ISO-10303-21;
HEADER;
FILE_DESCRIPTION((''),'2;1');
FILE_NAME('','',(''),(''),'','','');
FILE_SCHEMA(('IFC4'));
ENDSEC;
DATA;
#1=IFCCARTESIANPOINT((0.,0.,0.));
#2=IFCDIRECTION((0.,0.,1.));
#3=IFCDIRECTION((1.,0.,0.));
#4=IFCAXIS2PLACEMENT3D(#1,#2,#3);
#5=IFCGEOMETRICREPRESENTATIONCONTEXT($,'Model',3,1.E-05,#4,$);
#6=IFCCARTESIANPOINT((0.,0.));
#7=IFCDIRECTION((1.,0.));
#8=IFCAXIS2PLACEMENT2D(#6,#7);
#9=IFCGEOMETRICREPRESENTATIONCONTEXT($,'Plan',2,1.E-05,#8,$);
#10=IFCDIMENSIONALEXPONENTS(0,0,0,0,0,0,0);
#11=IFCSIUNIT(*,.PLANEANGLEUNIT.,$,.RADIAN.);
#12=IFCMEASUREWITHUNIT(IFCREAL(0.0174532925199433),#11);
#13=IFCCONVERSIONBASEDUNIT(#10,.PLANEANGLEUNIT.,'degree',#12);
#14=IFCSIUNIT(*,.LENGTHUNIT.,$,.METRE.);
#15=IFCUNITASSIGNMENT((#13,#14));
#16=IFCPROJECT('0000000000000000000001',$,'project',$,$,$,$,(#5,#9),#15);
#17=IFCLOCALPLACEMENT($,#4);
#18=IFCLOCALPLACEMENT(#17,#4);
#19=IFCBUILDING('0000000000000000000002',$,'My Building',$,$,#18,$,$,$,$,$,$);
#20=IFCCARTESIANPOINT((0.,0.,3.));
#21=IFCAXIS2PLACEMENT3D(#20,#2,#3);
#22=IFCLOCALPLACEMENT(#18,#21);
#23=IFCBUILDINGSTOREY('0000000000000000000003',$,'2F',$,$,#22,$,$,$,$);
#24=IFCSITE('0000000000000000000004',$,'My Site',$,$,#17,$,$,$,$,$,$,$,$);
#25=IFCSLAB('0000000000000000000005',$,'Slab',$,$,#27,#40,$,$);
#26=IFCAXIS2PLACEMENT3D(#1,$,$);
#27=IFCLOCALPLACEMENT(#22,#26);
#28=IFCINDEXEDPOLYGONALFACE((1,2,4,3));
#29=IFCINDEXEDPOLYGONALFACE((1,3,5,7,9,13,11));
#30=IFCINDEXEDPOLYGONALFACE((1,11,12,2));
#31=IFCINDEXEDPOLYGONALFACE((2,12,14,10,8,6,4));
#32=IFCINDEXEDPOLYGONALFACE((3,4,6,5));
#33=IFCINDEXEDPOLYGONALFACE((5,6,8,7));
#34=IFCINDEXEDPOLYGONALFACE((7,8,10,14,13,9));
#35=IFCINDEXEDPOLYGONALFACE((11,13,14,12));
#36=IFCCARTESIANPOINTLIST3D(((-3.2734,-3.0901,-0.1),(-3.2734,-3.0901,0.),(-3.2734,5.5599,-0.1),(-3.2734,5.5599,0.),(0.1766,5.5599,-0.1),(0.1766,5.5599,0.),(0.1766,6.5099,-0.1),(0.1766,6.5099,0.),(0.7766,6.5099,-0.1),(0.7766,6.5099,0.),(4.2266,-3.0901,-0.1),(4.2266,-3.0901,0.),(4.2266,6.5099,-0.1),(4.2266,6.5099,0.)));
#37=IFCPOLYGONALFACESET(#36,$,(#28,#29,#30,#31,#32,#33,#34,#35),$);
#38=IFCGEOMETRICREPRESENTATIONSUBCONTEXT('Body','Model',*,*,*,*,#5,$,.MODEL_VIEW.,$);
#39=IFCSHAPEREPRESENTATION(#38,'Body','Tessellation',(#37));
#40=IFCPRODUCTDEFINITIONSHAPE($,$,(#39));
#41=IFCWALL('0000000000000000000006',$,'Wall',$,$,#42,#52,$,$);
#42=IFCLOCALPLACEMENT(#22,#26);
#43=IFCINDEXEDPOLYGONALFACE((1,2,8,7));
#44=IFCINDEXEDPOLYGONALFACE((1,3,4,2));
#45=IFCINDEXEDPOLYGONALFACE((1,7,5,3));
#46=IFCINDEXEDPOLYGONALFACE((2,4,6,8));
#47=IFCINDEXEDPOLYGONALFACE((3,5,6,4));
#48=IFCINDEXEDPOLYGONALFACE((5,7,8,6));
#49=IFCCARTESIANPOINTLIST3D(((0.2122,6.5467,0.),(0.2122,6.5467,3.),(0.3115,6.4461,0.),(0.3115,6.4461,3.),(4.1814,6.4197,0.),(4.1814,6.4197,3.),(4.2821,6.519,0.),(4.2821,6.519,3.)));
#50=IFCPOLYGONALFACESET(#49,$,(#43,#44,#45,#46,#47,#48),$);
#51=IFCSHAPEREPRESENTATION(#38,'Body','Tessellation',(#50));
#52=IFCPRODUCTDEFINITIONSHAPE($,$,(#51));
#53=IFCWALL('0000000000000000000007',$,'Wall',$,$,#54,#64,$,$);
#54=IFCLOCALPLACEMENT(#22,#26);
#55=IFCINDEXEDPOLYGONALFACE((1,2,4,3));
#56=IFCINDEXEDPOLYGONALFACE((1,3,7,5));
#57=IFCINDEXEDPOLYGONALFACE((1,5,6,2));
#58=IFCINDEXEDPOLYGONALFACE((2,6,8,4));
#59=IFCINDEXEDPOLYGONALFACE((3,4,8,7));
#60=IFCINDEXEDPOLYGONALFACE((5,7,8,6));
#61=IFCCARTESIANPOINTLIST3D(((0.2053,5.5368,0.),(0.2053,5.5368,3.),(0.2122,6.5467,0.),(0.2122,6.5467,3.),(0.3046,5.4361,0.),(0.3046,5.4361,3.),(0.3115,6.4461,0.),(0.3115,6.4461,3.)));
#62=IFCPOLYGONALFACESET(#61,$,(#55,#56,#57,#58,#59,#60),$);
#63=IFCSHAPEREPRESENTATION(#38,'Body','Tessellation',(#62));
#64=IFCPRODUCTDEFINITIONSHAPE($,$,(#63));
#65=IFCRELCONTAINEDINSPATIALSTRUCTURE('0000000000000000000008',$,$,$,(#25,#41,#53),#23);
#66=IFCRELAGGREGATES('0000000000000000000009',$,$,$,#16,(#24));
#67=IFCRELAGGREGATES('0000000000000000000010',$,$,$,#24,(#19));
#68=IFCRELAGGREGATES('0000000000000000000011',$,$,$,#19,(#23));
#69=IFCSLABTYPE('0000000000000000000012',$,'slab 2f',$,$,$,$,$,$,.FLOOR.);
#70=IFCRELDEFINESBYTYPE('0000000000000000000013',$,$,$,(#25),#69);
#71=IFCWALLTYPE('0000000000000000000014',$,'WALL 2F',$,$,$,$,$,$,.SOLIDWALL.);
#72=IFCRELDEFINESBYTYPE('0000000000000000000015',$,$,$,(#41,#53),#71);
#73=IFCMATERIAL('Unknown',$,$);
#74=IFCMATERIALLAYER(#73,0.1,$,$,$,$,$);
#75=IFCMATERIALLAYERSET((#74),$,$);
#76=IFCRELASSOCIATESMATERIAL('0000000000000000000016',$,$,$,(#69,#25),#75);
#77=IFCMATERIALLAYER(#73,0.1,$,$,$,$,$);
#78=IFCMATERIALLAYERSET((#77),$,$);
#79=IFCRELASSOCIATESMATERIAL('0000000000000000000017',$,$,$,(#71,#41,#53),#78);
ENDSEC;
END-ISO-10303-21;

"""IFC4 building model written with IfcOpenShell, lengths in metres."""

from ifc_helpers import new_model, entity, si_unit, converted_unit, frame, origin_with_axes, origin_2d_with_axis, place, context, subcontext, project, spatial, line, indexed_curve, outline, extrude, material, layer, layer_set, layer_usage, type_object, element, save


model = new_model("IFC4")

# Units and contexts
model_context = context("Model", 3, precision=1e-05, world=origin_with_axes())
plan_context = context("Plan", 2, precision=1e-05, world=origin_2d_with_axis())
body_context_1 = subcontext(model_context, "Body", "Model", "MODEL_VIEW")
ifc_project = project(units=[converted_unit("PLANEANGLEUNIT", "degree", entity("IfcReal", 0.0174532925199433), si_unit("PLANEANGLEUNIT", "RADIAN"), dimensions=[0, 0, 0, 0, 0, 0, 0]), si_unit("LENGTHUNIT", "METRE")], contexts=[model_context, plan_context])

# Site, building, storey
site_placement = place(None, origin_with_axes())
site = spatial("IfcSite", under=ifc_project, at=site_placement, Name="My Site")
building_placement = place(site_placement, origin_with_axes())
building = spatial("IfcBuilding", under=site, at=building_placement, Name="My Building")
storey_placement = place(building_placement, frame((0.0, 0.0, 3.0), z_axis=(0.0, 0.0, 1.0), x_axis=(1.0, 0.0, 0.0)))
storey = spatial("IfcBuildingStorey", under=building, at=storey_placement, Name="2F")

# Slab
ifc_material = material(Name="Unknown")
ifc_layer_1 = layer(ifc_material, 0.1)
ifc_layer_set_1 = layer_set([ifc_layer_1])
ifc_layer_usage_1 = layer_usage(ifc_layer_set_1, "AXIS3", "POSITIVE", -0.1)
slab_type = type_object("IfcSlabType", Name="slab 2f", PredefinedType="FLOOR", material=ifc_layer_set_1)
slab_placement = place(storey_placement, frame((0.7766, 6.5099, 0.0), z_axis=(0.0, 0.0, 1.0), x_axis=(1.0, 0.0, 0.0)))
element("IfcSlab", 1, at=slab_placement, inside=storey, type_object=slab_type, material=ifc_layer_usage_1, Name="Slab", context=body_context_1, shape_type="SweptSolid", body=[
    extrude(outline(indexed_curve([(0.0, 0.0), (-0.6, 0.0), (-0.6, -0.95), (-4.05, -0.95), (-4.05, -9.6), (3.45, -9.6), (3.45, 0.0), (0.0, 0.0)])), frame((0.0, 0.0, -0.1), z_axis=(0.0, 0.0, 1.0), x_axis=(1.0, 0.0, 0.0)), (0.0, 0.0, 1.0), 0.1),
])

# Walls
ifc_layer_2 = layer(ifc_material, 0.1)
ifc_layer_set_2 = layer_set([ifc_layer_2])
ifc_layer_usage_2 = layer_usage(ifc_layer_set_2, "AXIS2", "POSITIVE", 0.0)
wall_type = type_object("IfcWallType", Name="WALL 2F", PredefinedType="SOLIDWALL", material=ifc_layer_set_2)
wall_1_placement = place(storey_placement, frame((4.2821, 6.519, 0.0), z_axis=(0.0, 0.0, 1.0), x_axis=(-0.999977, 0.006814, 0.0)))
element("IfcWall", 2, at=wall_1_placement, inside=storey, type_object=wall_type, material=ifc_layer_usage_2, Name="Wall", context=body_context_1, shape_type="SweptSolid", body=[
    extrude(outline(indexed_curve([(0.0, 0.0), (0.1, 0.1), (3.97, 0.1), (4.07, 0.0)], segments=[line(1, 2, 3, 4, 1)])), origin_with_axes(), (0.0, 0.0, 1.0), 3.0),
])
ifc_layer_usage_3 = layer_usage(ifc_layer_set_2, "AXIS2", "POSITIVE", 0.0)
wall_2_placement = place(storey_placement, frame((0.2122, 6.5467, 0.0), z_axis=(0.0, 0.0, 1.0), x_axis=(-0.006815, -0.999977, 0.0)))
element("IfcWall", 3, at=wall_2_placement, inside=storey, type_object=wall_type, material=ifc_layer_usage_3, Name="Wall", context=body_context_1, shape_type="SweptSolid", body=[
    extrude(outline(indexed_curve([(0.0, 0.0), (0.1, 0.1), (1.11, 0.1), (1.01, 0.0)], segments=[line(1, 2, 3, 4, 1)])), origin_with_axes(), (0.0, 0.0, 1.0), 3.0),
])

save(model, "model.ifc")
